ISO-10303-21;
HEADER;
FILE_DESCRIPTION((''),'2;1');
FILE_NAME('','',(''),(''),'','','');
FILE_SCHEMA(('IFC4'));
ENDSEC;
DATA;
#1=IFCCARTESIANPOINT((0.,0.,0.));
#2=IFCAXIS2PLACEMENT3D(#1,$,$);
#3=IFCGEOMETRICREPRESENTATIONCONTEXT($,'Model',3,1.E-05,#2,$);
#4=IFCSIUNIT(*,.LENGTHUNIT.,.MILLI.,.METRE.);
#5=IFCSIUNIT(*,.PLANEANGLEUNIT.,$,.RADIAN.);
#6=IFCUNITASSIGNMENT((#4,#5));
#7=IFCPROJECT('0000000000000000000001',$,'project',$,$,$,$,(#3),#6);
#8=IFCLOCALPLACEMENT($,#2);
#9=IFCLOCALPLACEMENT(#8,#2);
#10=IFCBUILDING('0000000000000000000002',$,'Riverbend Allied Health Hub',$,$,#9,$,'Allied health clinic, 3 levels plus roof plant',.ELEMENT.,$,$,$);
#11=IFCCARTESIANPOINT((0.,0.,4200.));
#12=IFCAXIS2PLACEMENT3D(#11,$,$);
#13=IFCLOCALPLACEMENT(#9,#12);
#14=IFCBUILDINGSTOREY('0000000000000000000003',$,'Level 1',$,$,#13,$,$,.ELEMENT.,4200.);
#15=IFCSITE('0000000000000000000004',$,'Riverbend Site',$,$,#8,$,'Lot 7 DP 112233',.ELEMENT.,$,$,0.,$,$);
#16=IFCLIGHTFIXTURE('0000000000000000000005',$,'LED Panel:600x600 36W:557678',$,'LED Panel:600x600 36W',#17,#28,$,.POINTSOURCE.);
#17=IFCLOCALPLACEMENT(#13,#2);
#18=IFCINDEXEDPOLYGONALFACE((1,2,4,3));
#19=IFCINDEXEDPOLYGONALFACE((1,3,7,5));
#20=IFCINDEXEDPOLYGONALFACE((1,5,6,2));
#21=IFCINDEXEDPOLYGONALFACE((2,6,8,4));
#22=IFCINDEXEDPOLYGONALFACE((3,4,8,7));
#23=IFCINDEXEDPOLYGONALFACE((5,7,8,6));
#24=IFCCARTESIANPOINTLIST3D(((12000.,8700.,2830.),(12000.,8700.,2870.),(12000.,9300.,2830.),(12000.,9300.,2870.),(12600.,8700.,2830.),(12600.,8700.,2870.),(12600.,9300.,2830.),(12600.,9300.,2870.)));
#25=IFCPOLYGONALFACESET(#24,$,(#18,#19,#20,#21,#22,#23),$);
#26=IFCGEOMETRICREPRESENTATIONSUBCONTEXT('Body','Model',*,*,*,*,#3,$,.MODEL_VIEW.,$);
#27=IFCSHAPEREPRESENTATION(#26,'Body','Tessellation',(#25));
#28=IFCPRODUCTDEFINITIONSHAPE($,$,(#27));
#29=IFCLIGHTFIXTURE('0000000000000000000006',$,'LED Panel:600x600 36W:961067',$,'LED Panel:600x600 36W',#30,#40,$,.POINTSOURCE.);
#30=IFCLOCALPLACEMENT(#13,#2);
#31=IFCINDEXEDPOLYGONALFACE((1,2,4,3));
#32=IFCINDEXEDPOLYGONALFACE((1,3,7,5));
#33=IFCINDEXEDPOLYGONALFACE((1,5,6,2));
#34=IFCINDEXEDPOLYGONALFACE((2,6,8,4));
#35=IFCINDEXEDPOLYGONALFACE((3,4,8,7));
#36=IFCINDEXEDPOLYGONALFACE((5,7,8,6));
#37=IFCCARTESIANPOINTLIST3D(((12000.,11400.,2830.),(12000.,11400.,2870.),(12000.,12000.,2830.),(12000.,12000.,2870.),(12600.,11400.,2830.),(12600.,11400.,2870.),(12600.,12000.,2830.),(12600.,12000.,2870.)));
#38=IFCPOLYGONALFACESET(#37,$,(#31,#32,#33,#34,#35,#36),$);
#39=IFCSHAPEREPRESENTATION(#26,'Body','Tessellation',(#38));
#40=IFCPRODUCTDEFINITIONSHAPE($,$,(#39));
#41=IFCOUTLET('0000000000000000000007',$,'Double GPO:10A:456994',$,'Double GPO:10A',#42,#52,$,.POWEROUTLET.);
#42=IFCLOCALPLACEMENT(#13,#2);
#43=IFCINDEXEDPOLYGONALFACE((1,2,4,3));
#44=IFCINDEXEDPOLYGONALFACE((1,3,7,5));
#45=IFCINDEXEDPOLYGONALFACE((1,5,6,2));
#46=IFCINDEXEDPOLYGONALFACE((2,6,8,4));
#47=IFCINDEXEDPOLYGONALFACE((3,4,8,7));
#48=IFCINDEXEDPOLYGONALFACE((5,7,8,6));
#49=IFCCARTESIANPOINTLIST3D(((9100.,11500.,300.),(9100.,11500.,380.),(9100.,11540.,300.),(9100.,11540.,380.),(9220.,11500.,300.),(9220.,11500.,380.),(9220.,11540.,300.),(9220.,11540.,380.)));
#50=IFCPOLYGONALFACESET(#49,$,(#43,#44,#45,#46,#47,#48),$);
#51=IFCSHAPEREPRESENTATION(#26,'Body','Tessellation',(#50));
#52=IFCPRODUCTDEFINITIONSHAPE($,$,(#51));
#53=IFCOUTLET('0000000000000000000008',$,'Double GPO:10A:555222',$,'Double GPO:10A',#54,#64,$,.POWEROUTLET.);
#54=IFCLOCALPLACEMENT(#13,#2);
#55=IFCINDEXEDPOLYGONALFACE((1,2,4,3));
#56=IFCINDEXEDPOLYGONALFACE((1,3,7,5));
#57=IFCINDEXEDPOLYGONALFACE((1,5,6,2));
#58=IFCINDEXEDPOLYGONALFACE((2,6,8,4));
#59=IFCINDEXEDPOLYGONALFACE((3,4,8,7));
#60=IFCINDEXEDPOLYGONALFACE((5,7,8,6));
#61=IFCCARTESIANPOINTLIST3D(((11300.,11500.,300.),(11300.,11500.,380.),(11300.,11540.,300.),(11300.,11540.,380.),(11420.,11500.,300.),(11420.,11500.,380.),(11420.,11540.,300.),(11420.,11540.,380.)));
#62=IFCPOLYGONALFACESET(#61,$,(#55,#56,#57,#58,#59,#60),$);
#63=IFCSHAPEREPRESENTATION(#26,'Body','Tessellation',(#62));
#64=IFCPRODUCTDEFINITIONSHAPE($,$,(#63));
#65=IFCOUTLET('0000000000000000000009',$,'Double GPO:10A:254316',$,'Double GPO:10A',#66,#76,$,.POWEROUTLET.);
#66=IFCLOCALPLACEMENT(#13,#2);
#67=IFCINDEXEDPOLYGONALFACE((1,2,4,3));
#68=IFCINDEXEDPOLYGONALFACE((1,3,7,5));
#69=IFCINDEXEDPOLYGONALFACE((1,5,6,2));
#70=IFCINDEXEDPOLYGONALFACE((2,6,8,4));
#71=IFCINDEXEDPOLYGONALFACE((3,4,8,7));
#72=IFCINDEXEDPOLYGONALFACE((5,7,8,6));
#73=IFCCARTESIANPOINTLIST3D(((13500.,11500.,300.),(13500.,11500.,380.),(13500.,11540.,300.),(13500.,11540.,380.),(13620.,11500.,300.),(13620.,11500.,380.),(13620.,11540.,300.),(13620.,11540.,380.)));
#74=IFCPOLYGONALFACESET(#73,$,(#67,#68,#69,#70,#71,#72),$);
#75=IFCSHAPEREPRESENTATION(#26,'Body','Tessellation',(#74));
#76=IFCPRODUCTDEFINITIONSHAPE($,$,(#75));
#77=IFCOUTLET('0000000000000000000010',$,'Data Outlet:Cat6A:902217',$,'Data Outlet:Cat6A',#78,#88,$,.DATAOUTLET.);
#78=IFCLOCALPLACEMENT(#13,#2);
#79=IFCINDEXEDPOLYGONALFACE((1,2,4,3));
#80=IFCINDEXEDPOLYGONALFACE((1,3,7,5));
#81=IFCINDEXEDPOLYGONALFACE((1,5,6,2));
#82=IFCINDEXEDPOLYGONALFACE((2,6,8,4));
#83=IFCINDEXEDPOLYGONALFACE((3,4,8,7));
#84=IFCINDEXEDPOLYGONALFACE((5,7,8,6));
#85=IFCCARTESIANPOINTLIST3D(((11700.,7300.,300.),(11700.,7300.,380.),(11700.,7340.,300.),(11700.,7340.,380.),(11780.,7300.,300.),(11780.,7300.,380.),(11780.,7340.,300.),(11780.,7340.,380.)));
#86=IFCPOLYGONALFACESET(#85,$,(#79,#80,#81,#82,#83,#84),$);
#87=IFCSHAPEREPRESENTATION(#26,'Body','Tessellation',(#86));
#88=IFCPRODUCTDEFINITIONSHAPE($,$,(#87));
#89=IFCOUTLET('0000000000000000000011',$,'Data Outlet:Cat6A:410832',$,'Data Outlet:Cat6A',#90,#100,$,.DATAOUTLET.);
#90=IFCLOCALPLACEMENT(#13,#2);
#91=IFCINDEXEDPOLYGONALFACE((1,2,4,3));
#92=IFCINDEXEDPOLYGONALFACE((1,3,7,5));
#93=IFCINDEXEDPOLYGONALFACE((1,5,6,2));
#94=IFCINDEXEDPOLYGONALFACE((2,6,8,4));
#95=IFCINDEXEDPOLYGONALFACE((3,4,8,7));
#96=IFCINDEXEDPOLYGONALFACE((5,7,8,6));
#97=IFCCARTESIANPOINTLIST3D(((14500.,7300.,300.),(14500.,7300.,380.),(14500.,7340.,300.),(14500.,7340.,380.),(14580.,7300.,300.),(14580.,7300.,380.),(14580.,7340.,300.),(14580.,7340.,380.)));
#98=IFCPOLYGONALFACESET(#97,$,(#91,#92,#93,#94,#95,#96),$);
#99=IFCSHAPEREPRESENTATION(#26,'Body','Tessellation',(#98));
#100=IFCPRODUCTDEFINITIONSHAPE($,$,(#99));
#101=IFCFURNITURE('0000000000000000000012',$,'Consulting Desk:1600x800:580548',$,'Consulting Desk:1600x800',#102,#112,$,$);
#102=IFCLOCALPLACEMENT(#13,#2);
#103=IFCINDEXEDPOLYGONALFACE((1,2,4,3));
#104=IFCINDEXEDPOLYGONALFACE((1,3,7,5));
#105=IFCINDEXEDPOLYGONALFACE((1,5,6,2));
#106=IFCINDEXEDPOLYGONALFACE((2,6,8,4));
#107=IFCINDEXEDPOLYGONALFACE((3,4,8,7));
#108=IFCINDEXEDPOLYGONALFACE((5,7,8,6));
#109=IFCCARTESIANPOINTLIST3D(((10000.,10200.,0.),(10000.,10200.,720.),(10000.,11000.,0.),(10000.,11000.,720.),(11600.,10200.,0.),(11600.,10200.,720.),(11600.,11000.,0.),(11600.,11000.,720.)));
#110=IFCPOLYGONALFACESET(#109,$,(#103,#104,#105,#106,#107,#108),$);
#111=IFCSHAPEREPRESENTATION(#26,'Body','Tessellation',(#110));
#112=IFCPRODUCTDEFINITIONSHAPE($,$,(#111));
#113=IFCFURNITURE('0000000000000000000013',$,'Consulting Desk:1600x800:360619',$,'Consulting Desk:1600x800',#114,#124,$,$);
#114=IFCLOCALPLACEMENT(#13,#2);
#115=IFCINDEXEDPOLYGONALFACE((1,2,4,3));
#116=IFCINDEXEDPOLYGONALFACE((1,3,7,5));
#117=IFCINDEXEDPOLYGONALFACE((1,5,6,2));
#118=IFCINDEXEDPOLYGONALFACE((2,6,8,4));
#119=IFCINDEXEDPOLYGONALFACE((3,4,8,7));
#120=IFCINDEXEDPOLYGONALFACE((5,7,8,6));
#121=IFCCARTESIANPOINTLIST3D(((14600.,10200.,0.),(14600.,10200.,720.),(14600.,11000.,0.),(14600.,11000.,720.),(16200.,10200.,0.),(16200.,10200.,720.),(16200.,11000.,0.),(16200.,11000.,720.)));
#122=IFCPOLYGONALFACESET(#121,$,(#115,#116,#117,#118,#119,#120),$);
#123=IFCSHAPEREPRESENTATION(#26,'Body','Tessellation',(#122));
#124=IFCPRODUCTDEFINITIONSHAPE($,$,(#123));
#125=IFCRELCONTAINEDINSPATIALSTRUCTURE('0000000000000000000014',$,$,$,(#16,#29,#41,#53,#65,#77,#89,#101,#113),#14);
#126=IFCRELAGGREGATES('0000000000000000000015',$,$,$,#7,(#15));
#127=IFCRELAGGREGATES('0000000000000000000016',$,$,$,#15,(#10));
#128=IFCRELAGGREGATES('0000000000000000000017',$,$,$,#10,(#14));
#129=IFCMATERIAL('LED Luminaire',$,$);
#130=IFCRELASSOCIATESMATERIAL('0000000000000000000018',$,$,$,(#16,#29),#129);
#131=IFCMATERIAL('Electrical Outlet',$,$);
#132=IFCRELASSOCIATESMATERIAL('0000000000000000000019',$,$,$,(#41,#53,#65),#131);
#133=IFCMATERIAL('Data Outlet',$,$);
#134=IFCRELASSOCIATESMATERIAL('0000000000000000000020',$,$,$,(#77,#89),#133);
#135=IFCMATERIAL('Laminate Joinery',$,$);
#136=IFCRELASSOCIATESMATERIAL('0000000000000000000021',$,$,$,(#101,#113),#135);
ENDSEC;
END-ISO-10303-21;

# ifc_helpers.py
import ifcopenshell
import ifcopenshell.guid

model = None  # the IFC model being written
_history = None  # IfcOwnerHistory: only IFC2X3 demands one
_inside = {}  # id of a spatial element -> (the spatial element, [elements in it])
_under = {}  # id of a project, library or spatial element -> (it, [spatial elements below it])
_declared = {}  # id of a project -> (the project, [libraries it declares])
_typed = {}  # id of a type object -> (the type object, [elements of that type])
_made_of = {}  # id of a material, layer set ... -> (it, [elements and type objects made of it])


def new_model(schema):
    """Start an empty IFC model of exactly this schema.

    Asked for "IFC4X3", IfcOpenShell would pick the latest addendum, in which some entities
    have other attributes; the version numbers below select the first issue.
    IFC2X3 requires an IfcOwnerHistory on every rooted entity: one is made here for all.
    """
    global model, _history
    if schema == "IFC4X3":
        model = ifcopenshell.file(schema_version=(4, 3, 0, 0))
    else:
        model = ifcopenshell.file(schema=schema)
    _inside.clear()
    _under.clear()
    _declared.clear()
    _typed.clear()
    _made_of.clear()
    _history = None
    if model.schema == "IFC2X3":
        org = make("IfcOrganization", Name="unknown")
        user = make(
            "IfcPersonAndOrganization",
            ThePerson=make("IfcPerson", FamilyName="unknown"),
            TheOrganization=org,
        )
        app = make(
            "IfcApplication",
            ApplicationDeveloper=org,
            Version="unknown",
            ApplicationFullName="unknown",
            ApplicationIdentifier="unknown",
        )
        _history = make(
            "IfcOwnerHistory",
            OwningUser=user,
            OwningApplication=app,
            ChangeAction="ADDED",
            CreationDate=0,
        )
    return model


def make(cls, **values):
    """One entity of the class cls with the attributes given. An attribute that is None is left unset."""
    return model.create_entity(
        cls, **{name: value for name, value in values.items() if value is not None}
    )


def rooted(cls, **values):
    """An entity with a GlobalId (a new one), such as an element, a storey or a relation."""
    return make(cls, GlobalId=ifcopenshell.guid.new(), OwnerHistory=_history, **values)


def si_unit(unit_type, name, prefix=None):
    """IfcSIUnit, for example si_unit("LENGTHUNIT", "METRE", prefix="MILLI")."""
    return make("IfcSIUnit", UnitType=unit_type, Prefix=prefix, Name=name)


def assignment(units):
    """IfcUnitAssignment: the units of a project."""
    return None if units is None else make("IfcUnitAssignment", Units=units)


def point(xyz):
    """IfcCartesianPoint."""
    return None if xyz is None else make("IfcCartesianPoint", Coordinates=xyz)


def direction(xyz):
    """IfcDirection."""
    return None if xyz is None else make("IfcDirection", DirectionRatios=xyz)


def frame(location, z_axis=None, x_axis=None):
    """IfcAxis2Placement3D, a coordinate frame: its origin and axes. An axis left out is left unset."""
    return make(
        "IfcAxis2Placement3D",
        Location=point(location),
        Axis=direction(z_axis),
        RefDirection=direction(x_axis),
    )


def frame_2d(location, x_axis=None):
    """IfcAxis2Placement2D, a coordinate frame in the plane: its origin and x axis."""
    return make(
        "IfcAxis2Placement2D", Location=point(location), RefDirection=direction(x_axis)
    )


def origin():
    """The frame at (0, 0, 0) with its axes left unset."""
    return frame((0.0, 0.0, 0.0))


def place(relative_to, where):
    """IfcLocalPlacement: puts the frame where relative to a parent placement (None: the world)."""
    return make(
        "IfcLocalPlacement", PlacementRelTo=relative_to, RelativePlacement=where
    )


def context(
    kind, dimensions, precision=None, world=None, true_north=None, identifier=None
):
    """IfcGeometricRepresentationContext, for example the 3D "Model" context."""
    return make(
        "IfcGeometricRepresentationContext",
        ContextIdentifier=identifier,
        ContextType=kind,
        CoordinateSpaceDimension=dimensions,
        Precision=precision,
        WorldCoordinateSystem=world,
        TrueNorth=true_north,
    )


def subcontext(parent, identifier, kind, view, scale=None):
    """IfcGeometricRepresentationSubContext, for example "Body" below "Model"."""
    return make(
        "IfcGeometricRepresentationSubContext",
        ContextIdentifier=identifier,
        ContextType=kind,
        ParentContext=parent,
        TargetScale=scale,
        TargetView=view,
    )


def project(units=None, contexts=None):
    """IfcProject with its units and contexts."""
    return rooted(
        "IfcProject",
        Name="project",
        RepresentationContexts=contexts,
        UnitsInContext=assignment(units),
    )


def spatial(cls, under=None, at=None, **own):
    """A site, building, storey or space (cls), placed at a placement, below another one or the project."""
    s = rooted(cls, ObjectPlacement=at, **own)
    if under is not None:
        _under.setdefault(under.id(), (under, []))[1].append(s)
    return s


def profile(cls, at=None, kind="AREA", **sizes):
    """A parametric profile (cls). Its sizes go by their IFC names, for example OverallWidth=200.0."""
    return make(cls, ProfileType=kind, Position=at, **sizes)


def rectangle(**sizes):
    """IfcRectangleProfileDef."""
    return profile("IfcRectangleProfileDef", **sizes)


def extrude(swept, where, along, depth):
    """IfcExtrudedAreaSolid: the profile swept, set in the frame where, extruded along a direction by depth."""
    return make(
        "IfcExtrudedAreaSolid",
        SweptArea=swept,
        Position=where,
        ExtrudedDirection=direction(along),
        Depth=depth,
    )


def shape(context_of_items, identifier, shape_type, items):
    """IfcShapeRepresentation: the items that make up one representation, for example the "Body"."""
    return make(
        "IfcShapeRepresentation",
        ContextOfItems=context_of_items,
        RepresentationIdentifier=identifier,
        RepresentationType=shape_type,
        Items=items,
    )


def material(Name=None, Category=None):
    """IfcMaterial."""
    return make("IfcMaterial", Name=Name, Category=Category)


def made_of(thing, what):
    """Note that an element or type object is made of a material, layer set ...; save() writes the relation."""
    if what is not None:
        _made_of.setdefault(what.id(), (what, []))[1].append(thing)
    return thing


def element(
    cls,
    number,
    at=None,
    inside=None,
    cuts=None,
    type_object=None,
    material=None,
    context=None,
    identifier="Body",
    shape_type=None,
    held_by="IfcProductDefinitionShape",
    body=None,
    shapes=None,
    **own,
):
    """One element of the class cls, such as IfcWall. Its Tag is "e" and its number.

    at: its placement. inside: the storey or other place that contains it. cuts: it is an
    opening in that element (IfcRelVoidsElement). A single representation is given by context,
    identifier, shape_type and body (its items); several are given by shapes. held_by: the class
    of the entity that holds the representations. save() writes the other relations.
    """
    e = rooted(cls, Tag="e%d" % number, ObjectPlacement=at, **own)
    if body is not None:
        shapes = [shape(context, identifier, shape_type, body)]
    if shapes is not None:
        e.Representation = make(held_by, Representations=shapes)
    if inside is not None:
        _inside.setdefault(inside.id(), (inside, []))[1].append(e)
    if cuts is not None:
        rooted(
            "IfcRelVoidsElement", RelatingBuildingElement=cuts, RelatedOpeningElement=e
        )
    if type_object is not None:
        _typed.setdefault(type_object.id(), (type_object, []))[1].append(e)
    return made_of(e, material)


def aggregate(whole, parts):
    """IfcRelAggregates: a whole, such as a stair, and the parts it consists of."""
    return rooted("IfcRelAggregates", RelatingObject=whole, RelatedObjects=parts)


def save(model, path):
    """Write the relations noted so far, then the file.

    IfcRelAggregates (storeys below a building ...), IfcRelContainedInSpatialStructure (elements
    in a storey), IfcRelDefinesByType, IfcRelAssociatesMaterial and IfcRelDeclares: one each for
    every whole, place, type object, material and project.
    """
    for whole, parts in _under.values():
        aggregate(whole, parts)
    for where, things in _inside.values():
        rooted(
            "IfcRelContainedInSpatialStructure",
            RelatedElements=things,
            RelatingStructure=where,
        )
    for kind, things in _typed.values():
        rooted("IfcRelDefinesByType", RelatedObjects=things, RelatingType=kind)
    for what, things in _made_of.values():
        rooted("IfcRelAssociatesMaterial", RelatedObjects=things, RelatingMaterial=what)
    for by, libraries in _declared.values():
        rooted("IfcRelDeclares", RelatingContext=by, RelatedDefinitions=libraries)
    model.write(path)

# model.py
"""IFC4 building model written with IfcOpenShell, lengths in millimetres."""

from ifc_helpers import new_model, si_unit, frame, frame_2d, origin, place, context, subcontext, project, spatial, rectangle, extrude, material, element, save


model = new_model("IFC4")

# Units and contexts
model_context = context("Model", 3, precision=1e-05, world=origin())
body_context = subcontext(model_context, "Body", "Model", "MODEL_VIEW")
ifc_project = project(units=[si_unit("LENGTHUNIT", "METRE", prefix="MILLI"), si_unit("PLANEANGLEUNIT", "RADIAN")], contexts=[model_context])

# Site, building, storey
site_placement = place(None, origin())
site = spatial("IfcSite", under=ifc_project, at=site_placement, Name="Riverbend Site", LongName="Lot 7 DP 112233", CompositionType="ELEMENT", RefElevation=0.0)
building_placement = place(site_placement, origin())
building = spatial("IfcBuilding", under=site, at=building_placement, Name="Riverbend Allied Health Hub", LongName="Allied health clinic, 3 levels plus roof plant", CompositionType="ELEMENT")
storey_placement = place(building_placement, frame((0.0, 0.0, 4200.0)))
storey = spatial("IfcBuildingStorey", under=building, at=storey_placement, Name="Level 1", CompositionType="ELEMENT", Elevation=4200.0)

# Light fixtures
ifc_material_1 = material(Name="LED Luminaire")
for number, where, name in (
    (1, (12000.0, 8700.0, 2830.0), "LED Panel:600x600 36W:557678"),
    (2, (12000.0, 11400.0, 2830.0), "LED Panel:600x600 36W:961067"),
):
    element("IfcLightFixture", number, at=place(storey_placement, frame(where)), inside=storey, material=ifc_material_1, Name=name, ObjectType="LED Panel:600x600 36W", PredefinedType="POINTSOURCE", context=body_context, shape_type="SweptSolid", body=[
        extrude(rectangle(XDim=600.0, YDim=600.0, at=frame_2d((300.0, 300.0))), origin(), (0.0, 0.0, 1.0), 40.0),
    ])

# Outlets
ifc_material_2 = material(Name="Electrical Outlet")
for number, where, name in (
    (3, (9100.0, 11500.0, 300.0), "Double GPO:10A:456994"),
    (4, (11300.0, 11500.0, 300.0), "Double GPO:10A:555222"),
    (5, (13500.0, 11500.0, 300.0), "Double GPO:10A:254316"),
):
    element("IfcOutlet", number, at=place(storey_placement, frame(where)), inside=storey, material=ifc_material_2, Name=name, ObjectType="Double GPO:10A", PredefinedType="POWEROUTLET", context=body_context, shape_type="SweptSolid", body=[
        extrude(rectangle(XDim=120.0, YDim=40.0, at=frame_2d((60.0, 20.0))), origin(), (0.0, 0.0, 1.0), 80.0),
    ])
ifc_material_3 = material(Name="Data Outlet")
for number, where, name in (
    (6, (11700.0, 7300.0, 300.0), "Data Outlet:Cat6A:902217"),
    (7, (14500.0, 7300.0, 300.0), "Data Outlet:Cat6A:410832"),
):
    element("IfcOutlet", number, at=place(storey_placement, frame(where)), inside=storey, material=ifc_material_3, Name=name, ObjectType="Data Outlet:Cat6A", PredefinedType="DATAOUTLET", context=body_context, shape_type="SweptSolid", body=[
        extrude(rectangle(XDim=80.0, YDim=40.0, at=frame_2d((40.0, 20.0))), origin(), (0.0, 0.0, 1.0), 80.0),
    ])

# Furniture
ifc_material_4 = material(Name="Laminate Joinery")
for number, where, name in (
    (8, (10000.0, 10200.0, 0.0), "Consulting Desk:1600x800:580548"),
    (9, (14600.0, 10200.0, 0.0), "Consulting Desk:1600x800:360619"),
):
    element("IfcFurniture", number, at=place(storey_placement, frame(where)), inside=storey, material=ifc_material_4, Name=name, ObjectType="Consulting Desk:1600x800", context=body_context, shape_type="SweptSolid", body=[
        extrude(rectangle(XDim=1600.0, YDim=800.0, at=frame_2d((800.0, 400.0))), origin(), (0.0, 0.0, 1.0), 720.0),
    ])

save(model, "model.ifc")
